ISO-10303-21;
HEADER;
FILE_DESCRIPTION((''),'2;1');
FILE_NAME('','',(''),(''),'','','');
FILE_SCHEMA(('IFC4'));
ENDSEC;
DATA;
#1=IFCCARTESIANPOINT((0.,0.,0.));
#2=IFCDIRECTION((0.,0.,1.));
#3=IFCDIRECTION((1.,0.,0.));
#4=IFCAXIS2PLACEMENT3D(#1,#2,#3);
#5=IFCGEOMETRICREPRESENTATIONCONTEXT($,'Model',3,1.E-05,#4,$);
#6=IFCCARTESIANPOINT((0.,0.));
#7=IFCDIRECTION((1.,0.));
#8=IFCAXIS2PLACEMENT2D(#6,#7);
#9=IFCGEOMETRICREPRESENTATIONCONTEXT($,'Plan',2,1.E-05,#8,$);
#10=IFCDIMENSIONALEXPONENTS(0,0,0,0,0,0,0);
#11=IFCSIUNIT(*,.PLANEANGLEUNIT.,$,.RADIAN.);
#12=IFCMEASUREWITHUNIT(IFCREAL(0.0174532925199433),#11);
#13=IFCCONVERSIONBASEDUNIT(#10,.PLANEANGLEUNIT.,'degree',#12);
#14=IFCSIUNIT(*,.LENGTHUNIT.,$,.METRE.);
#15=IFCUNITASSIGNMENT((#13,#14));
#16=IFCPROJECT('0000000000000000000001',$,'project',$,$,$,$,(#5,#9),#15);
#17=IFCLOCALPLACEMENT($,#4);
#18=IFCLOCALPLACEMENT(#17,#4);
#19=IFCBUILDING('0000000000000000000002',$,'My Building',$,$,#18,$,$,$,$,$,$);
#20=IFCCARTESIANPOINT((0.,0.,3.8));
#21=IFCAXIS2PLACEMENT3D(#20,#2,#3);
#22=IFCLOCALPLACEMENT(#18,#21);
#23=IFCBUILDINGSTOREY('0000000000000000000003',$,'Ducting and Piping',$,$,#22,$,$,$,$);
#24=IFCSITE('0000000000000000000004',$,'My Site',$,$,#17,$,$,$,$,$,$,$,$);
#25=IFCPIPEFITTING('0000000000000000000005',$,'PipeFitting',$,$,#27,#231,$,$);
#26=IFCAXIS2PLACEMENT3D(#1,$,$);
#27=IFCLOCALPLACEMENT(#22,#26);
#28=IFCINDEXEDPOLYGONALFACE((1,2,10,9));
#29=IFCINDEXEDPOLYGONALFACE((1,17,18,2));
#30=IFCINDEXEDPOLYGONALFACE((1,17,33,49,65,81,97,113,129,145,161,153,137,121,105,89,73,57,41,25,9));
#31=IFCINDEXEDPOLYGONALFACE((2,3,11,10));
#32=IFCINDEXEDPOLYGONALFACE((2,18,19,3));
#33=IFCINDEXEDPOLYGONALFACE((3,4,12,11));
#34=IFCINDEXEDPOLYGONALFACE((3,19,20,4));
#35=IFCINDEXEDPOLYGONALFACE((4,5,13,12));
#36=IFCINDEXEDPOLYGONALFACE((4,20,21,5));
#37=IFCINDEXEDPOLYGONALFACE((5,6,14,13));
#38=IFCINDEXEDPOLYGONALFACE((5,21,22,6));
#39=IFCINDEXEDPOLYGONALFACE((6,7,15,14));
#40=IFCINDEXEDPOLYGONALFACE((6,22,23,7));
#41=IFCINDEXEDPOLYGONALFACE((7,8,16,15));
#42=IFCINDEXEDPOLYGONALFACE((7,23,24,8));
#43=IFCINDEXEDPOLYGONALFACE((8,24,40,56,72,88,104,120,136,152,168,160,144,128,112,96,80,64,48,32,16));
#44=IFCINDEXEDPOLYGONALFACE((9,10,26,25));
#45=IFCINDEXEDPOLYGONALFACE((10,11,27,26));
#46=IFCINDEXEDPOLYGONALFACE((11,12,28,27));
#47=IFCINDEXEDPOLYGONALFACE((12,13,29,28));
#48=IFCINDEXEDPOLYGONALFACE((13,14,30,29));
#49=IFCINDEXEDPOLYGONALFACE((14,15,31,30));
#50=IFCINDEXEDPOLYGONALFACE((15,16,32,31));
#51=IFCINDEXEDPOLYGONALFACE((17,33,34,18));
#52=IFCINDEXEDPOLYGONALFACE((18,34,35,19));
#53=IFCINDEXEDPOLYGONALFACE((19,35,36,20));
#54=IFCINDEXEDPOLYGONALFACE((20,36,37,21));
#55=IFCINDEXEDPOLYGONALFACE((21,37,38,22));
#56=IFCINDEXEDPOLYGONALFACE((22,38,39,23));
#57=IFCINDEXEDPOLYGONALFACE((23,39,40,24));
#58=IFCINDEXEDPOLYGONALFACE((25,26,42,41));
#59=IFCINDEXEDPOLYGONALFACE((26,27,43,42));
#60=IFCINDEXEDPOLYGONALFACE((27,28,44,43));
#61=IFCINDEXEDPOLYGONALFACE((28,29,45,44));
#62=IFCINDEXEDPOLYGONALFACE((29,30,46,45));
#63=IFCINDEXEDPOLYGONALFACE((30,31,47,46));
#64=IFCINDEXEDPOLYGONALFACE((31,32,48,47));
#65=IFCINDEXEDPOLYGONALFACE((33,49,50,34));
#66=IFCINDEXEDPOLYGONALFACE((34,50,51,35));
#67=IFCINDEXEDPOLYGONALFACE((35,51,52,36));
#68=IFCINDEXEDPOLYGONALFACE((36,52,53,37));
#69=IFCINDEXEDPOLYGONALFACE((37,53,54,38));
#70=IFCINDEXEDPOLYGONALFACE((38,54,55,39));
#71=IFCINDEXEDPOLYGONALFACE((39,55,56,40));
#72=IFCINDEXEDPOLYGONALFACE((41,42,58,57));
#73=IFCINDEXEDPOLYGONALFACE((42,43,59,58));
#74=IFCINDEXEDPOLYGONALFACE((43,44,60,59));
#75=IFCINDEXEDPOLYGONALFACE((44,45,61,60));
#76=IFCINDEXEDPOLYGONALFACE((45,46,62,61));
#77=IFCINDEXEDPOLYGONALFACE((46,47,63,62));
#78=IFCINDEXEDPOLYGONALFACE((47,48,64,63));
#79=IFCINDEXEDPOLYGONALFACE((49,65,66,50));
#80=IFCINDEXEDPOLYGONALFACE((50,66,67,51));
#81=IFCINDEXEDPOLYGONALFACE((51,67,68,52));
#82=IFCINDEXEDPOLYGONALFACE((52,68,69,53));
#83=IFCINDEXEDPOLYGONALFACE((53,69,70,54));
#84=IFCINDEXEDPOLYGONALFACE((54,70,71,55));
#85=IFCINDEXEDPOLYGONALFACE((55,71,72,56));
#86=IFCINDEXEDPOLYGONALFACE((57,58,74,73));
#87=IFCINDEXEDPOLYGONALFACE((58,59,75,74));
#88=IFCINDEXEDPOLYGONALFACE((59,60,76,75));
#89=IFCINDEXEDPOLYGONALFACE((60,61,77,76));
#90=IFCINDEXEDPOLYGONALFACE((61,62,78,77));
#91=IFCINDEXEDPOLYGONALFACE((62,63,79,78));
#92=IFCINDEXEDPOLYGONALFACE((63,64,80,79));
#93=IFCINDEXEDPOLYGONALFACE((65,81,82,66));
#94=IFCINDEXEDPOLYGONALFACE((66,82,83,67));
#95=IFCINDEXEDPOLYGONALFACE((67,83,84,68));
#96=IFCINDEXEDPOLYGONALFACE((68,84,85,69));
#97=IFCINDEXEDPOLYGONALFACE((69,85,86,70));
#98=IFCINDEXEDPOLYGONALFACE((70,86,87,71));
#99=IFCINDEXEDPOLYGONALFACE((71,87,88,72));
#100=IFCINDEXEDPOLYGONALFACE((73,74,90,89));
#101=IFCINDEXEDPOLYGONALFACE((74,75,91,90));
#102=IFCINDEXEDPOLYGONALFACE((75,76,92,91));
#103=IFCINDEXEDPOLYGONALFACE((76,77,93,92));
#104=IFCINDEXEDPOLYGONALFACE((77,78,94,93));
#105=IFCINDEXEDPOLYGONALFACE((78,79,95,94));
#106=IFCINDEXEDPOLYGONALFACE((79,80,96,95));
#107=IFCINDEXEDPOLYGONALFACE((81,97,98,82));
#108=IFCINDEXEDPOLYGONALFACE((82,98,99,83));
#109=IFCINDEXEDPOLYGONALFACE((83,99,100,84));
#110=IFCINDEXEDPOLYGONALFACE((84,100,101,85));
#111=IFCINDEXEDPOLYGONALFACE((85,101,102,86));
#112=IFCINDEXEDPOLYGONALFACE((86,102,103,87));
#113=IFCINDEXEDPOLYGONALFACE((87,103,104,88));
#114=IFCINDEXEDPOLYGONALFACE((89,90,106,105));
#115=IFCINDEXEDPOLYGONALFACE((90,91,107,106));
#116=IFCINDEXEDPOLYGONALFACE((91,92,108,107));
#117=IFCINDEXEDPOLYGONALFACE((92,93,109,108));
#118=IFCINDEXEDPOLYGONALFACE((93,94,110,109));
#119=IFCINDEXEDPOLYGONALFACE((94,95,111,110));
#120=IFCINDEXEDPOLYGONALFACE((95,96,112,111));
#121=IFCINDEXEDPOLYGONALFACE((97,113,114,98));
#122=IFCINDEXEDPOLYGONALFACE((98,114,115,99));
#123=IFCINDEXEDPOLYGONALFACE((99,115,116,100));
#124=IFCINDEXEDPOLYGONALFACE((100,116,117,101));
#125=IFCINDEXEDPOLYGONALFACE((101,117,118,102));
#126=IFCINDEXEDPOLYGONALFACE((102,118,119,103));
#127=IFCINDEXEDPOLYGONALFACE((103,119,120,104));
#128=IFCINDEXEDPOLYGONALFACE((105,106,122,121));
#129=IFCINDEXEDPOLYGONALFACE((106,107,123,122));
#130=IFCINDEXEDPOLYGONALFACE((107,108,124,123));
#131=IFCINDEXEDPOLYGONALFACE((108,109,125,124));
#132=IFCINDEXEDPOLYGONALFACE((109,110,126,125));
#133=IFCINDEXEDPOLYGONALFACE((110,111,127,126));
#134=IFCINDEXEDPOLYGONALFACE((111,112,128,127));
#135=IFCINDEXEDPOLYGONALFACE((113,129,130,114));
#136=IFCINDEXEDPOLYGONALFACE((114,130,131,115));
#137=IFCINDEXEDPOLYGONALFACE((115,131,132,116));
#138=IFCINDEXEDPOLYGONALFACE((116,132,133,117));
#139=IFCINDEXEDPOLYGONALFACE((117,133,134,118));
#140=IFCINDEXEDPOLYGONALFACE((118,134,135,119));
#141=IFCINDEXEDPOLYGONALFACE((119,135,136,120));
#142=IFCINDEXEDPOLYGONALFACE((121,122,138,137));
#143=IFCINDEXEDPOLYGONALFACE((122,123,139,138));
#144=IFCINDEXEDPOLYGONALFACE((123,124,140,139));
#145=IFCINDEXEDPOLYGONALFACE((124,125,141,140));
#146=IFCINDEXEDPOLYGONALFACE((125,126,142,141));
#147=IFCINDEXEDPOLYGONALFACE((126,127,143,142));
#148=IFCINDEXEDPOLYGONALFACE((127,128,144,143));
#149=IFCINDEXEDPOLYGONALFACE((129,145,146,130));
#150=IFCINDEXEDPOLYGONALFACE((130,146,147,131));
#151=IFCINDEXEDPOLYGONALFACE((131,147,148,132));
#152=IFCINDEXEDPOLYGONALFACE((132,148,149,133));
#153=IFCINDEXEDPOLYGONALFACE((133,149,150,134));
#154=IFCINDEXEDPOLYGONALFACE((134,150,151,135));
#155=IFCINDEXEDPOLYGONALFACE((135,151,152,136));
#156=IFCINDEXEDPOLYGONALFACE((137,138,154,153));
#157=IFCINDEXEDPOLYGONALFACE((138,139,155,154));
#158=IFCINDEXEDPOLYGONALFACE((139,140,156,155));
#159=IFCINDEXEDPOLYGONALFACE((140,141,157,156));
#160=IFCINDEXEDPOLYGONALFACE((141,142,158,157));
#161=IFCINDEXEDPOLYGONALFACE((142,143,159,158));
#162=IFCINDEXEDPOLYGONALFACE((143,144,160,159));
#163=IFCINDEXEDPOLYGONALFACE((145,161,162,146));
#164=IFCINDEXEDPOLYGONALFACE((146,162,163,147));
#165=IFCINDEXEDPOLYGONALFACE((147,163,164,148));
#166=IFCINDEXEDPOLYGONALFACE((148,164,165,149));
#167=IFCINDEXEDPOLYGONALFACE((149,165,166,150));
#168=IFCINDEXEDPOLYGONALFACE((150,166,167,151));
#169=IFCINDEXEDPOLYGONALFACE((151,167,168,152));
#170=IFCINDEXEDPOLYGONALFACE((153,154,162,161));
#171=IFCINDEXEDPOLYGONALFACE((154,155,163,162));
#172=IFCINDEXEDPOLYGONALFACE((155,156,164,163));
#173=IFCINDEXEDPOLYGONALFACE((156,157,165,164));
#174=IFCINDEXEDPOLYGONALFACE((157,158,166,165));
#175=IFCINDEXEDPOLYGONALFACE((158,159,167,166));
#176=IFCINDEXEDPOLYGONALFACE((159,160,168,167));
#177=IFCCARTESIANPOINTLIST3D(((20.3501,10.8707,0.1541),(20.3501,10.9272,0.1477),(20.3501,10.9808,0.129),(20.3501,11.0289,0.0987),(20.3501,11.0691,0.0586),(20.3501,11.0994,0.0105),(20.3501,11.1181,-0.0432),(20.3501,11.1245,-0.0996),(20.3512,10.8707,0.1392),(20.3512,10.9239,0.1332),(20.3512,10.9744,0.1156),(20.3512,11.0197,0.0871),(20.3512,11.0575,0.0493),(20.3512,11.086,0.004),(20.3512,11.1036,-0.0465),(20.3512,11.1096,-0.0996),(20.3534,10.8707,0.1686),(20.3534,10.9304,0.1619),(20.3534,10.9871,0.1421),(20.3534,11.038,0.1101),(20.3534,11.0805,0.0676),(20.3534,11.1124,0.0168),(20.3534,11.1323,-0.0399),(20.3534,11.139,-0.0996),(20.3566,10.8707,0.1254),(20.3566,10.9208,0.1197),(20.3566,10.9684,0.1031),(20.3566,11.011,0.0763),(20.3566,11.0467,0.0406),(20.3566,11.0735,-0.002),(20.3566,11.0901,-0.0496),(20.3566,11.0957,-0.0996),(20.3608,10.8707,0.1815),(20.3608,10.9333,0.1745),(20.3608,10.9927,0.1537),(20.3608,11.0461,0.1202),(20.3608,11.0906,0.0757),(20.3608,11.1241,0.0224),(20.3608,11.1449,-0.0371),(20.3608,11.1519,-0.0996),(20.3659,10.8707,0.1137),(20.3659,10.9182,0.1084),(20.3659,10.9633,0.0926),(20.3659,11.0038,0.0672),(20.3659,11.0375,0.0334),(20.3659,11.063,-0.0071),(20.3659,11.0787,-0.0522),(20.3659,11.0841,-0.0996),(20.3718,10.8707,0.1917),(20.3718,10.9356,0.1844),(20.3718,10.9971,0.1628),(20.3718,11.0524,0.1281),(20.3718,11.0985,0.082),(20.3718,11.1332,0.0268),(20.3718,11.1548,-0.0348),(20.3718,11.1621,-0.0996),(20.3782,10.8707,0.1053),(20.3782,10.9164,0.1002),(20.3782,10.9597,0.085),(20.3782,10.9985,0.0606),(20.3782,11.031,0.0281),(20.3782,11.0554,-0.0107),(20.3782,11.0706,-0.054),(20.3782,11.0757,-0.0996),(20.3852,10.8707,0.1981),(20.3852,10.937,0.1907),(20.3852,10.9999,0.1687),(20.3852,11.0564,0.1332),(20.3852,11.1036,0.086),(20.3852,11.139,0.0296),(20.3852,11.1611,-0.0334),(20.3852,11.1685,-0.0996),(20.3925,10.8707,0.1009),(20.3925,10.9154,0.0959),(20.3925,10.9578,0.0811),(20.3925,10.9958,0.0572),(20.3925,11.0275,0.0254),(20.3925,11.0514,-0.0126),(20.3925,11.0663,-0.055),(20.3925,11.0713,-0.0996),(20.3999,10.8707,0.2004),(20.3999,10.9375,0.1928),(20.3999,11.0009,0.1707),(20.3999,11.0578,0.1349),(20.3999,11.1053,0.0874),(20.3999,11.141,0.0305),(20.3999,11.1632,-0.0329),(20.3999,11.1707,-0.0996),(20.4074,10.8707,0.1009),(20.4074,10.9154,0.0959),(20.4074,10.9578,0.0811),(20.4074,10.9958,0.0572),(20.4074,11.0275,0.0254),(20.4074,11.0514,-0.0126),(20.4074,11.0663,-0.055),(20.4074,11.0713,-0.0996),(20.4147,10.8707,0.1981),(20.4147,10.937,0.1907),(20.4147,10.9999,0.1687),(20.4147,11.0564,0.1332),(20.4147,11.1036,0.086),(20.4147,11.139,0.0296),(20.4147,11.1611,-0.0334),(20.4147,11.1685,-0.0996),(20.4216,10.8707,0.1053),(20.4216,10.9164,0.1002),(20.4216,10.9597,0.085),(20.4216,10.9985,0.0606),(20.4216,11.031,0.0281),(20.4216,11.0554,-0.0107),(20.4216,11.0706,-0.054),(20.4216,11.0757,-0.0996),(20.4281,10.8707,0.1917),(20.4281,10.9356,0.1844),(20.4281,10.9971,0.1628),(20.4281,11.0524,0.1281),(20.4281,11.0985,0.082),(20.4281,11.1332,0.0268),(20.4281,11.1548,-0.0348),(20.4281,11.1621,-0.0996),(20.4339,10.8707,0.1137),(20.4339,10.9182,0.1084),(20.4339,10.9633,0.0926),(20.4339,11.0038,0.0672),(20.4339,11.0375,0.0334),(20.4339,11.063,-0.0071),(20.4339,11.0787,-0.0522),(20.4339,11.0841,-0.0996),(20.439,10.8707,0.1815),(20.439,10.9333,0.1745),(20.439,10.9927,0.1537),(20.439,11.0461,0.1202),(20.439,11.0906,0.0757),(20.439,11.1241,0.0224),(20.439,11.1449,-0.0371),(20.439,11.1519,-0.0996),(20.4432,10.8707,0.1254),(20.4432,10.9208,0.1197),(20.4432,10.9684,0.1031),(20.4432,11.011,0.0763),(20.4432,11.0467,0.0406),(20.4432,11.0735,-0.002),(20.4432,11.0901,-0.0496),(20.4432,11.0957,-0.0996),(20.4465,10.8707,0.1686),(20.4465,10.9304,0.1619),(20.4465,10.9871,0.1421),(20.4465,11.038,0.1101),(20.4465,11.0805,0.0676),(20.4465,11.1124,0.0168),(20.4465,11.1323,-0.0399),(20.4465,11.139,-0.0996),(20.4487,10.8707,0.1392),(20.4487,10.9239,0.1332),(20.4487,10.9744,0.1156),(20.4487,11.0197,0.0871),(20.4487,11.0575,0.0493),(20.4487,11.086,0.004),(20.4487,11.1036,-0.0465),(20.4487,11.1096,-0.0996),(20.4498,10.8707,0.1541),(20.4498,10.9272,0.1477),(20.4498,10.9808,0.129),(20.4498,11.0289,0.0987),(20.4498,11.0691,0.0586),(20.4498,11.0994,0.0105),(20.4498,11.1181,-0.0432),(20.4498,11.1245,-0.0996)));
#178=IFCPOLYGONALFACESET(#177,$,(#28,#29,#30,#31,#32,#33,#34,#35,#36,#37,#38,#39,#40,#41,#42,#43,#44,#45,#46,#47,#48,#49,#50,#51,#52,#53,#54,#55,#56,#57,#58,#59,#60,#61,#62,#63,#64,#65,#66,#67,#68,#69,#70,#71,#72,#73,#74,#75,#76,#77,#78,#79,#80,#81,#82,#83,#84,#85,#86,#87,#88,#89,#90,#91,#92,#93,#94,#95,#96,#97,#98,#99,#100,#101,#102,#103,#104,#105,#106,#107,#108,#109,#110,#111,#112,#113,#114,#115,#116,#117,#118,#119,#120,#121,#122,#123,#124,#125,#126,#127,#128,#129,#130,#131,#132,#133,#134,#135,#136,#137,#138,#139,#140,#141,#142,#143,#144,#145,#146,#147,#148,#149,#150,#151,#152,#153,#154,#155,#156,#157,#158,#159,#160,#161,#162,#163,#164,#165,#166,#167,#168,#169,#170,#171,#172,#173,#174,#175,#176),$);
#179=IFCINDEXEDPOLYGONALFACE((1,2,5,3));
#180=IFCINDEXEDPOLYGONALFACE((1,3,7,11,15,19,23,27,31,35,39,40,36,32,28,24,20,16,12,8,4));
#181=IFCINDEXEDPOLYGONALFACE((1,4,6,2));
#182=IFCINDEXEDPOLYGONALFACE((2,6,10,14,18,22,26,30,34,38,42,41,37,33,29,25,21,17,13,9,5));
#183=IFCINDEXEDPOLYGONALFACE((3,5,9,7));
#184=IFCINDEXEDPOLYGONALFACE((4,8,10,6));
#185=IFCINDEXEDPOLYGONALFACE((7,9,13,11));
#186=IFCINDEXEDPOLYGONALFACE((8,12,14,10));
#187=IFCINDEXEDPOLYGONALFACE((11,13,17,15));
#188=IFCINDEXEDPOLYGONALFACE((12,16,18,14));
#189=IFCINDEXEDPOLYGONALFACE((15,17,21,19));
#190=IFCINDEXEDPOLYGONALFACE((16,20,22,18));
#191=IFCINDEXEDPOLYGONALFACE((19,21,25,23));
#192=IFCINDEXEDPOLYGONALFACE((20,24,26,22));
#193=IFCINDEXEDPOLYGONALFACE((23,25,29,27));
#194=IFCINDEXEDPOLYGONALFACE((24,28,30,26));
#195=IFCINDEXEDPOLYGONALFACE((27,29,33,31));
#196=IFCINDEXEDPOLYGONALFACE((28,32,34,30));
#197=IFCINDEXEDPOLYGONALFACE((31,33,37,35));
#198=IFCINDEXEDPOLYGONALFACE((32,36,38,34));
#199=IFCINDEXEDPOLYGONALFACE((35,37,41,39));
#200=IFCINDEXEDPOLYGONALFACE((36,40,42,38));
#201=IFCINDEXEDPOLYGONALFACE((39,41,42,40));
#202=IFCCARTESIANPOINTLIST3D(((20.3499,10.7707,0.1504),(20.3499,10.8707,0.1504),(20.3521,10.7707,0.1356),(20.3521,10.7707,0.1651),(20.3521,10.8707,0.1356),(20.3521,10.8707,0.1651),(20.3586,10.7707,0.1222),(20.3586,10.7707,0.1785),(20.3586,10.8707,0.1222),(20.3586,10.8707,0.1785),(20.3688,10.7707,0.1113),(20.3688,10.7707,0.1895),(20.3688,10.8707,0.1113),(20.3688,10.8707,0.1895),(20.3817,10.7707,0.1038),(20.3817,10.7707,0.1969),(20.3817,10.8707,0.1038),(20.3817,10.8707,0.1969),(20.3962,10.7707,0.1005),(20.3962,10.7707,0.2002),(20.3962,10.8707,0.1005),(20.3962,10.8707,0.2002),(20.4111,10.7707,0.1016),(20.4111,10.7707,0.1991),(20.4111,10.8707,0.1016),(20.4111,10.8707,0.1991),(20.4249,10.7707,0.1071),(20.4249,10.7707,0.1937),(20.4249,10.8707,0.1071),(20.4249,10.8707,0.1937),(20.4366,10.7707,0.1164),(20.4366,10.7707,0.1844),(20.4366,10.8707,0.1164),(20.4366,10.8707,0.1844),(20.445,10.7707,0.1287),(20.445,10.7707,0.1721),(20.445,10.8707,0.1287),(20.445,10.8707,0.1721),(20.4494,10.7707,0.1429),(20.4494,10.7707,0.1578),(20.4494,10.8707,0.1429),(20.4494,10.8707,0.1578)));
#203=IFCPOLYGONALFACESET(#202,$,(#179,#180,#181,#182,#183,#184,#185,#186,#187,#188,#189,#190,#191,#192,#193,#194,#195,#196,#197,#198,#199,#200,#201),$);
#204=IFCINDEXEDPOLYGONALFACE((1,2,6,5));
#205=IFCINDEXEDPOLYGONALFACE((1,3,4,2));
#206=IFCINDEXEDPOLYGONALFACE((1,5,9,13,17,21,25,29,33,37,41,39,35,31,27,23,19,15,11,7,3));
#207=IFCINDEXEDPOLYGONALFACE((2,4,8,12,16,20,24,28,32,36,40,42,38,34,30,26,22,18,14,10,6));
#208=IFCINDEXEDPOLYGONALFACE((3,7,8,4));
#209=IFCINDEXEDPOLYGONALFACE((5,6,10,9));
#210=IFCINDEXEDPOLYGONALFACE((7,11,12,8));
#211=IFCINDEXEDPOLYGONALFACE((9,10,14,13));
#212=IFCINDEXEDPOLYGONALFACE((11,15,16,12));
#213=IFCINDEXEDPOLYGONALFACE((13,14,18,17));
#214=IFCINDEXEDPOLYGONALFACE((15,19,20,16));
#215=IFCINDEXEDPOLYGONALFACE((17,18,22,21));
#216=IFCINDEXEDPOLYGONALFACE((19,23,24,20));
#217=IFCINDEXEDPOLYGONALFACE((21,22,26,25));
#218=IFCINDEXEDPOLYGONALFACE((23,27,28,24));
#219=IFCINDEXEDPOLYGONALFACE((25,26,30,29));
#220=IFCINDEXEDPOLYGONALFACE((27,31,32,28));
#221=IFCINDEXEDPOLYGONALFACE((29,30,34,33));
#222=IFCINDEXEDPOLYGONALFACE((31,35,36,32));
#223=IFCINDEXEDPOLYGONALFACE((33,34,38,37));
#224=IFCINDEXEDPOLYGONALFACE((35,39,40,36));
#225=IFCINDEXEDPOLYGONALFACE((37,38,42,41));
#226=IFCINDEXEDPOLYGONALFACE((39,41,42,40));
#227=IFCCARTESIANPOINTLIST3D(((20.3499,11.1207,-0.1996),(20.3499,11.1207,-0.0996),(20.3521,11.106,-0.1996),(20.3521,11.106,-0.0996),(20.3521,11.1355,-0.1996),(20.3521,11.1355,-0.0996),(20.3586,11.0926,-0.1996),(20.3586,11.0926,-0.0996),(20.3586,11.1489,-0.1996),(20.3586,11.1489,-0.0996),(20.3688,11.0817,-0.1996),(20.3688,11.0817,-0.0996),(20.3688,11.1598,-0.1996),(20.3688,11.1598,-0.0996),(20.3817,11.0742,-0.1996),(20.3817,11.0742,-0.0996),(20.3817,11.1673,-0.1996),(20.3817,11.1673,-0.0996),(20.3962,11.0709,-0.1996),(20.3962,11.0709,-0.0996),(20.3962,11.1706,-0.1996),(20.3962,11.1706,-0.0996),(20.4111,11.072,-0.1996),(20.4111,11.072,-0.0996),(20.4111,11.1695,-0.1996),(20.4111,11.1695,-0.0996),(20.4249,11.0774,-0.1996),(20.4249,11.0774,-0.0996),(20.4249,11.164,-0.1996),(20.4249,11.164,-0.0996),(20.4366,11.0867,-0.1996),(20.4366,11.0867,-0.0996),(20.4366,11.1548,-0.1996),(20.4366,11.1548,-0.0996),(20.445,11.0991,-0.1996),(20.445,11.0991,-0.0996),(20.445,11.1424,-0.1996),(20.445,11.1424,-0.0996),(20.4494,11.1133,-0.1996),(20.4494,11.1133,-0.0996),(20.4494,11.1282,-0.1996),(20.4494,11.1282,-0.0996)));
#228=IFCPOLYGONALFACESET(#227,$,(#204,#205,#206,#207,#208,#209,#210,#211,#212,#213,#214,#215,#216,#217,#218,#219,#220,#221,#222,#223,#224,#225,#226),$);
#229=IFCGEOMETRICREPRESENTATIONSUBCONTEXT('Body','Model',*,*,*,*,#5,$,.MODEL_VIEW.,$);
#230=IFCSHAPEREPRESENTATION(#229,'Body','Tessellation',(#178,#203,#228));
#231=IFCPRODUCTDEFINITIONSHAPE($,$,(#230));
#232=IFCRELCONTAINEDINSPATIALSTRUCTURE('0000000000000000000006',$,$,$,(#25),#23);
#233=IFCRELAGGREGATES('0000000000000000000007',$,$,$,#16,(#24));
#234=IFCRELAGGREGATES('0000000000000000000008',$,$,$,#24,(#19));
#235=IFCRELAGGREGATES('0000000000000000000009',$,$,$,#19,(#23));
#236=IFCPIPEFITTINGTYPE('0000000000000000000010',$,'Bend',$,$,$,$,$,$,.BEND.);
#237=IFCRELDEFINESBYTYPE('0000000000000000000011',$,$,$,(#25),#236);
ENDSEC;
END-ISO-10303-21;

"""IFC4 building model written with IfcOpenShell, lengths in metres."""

from ifc_helpers import new_model, entity, si_unit, converted_unit, frame, origin_with_axes, origin_2d_with_axis, place, context, subcontext, project, spatial, circle, extrude, source, transform, mapped, type_object, type_shapes, element, save


model = new_model("IFC4")

# Units and contexts
model_context = context("Model", 3, precision=1e-05, world=origin_with_axes())
plan_context = context("Plan", 2, precision=1e-05, world=origin_2d_with_axis())
body_context = subcontext(model_context, "Body", "Model", "MODEL_VIEW")
ifc_project = project(units=[converted_unit("PLANEANGLEUNIT", "degree", entity("IfcReal", 0.0174532925199433), si_unit("PLANEANGLEUNIT", "RADIAN"), dimensions=[0, 0, 0, 0, 0, 0, 0]), si_unit("LENGTHUNIT", "METRE")], contexts=[model_context, plan_context])

# Site, building, storey
site_placement = place(None, origin_with_axes())
site = spatial("IfcSite", under=ifc_project, at=site_placement, Name="My Site")
building_placement = place(site_placement, origin_with_axes())
building = spatial("IfcBuilding", under=site, at=building_placement, Name="My Building")
storey_placement = place(building_placement, frame((0.0, 0.0, 3.8), z_axis=(0.0, 0.0, 1.0), x_axis=(1.0, 0.0, 0.0)))
storey = spatial("IfcBuildingStorey", under=building, at=storey_placement, Name="Ducting and Piping")

# Pipe fitting
pipe_fitting_type = type_object("IfcPipeFittingType", Name="Bend", PredefinedType="BEND")
shared_shape = source(origin_with_axes(), body_context, "Body", "SolidModel", [
    entity("IfcSweptDiskSolid", entity("IfcIndexedPolyCurve", entity("IfcCartesianPointList3D", [[0.0, 0.0, 0.1], [0.0, -0.0732, 0.2768], [0.0, -0.25, 0.35]]), [entity("IfcArcIndex", [1, 2, 3])]), 0.05),
    extrude(circle(Radius=0.05), origin_with_axes(), (0.0, 0.0, 1.0), 0.1),
    extrude(circle(Radius=0.05), frame((0.0, -0.25, 0.35), z_axis=(0.0, -1.0, 0.0), x_axis=(1.0, 0.0, 0.0)), (0.0, 0.0, 1.0), 0.1),
])
type_shapes(pipe_fitting_type, [shared_shape])
for number, where, z_axis, x_axis, name in (
    (1, (20.3999, 10.7707, 0.1504), (0.0, 1.0, 0.0), (-1.0, 0.0, 0.0), "PipeFitting"),
):
    element("IfcPipeFitting", number, at=place(storey_placement, frame(where, z_axis=z_axis, x_axis=x_axis)), inside=storey, type_object=pipe_fitting_type, Name=name, context=body_context, shape_type="MappedRepresentation", body=[
        mapped(shared_shape, transform((0.0, 0.0, 0.0), x_axis=(1.0, 0.0, 0.0), y_axis=(0.0, 1.0, 0.0), z_axis=(0.0, 0.0, 1.0), scale=1.0)),
    ])

save(model, "model.ifc")
